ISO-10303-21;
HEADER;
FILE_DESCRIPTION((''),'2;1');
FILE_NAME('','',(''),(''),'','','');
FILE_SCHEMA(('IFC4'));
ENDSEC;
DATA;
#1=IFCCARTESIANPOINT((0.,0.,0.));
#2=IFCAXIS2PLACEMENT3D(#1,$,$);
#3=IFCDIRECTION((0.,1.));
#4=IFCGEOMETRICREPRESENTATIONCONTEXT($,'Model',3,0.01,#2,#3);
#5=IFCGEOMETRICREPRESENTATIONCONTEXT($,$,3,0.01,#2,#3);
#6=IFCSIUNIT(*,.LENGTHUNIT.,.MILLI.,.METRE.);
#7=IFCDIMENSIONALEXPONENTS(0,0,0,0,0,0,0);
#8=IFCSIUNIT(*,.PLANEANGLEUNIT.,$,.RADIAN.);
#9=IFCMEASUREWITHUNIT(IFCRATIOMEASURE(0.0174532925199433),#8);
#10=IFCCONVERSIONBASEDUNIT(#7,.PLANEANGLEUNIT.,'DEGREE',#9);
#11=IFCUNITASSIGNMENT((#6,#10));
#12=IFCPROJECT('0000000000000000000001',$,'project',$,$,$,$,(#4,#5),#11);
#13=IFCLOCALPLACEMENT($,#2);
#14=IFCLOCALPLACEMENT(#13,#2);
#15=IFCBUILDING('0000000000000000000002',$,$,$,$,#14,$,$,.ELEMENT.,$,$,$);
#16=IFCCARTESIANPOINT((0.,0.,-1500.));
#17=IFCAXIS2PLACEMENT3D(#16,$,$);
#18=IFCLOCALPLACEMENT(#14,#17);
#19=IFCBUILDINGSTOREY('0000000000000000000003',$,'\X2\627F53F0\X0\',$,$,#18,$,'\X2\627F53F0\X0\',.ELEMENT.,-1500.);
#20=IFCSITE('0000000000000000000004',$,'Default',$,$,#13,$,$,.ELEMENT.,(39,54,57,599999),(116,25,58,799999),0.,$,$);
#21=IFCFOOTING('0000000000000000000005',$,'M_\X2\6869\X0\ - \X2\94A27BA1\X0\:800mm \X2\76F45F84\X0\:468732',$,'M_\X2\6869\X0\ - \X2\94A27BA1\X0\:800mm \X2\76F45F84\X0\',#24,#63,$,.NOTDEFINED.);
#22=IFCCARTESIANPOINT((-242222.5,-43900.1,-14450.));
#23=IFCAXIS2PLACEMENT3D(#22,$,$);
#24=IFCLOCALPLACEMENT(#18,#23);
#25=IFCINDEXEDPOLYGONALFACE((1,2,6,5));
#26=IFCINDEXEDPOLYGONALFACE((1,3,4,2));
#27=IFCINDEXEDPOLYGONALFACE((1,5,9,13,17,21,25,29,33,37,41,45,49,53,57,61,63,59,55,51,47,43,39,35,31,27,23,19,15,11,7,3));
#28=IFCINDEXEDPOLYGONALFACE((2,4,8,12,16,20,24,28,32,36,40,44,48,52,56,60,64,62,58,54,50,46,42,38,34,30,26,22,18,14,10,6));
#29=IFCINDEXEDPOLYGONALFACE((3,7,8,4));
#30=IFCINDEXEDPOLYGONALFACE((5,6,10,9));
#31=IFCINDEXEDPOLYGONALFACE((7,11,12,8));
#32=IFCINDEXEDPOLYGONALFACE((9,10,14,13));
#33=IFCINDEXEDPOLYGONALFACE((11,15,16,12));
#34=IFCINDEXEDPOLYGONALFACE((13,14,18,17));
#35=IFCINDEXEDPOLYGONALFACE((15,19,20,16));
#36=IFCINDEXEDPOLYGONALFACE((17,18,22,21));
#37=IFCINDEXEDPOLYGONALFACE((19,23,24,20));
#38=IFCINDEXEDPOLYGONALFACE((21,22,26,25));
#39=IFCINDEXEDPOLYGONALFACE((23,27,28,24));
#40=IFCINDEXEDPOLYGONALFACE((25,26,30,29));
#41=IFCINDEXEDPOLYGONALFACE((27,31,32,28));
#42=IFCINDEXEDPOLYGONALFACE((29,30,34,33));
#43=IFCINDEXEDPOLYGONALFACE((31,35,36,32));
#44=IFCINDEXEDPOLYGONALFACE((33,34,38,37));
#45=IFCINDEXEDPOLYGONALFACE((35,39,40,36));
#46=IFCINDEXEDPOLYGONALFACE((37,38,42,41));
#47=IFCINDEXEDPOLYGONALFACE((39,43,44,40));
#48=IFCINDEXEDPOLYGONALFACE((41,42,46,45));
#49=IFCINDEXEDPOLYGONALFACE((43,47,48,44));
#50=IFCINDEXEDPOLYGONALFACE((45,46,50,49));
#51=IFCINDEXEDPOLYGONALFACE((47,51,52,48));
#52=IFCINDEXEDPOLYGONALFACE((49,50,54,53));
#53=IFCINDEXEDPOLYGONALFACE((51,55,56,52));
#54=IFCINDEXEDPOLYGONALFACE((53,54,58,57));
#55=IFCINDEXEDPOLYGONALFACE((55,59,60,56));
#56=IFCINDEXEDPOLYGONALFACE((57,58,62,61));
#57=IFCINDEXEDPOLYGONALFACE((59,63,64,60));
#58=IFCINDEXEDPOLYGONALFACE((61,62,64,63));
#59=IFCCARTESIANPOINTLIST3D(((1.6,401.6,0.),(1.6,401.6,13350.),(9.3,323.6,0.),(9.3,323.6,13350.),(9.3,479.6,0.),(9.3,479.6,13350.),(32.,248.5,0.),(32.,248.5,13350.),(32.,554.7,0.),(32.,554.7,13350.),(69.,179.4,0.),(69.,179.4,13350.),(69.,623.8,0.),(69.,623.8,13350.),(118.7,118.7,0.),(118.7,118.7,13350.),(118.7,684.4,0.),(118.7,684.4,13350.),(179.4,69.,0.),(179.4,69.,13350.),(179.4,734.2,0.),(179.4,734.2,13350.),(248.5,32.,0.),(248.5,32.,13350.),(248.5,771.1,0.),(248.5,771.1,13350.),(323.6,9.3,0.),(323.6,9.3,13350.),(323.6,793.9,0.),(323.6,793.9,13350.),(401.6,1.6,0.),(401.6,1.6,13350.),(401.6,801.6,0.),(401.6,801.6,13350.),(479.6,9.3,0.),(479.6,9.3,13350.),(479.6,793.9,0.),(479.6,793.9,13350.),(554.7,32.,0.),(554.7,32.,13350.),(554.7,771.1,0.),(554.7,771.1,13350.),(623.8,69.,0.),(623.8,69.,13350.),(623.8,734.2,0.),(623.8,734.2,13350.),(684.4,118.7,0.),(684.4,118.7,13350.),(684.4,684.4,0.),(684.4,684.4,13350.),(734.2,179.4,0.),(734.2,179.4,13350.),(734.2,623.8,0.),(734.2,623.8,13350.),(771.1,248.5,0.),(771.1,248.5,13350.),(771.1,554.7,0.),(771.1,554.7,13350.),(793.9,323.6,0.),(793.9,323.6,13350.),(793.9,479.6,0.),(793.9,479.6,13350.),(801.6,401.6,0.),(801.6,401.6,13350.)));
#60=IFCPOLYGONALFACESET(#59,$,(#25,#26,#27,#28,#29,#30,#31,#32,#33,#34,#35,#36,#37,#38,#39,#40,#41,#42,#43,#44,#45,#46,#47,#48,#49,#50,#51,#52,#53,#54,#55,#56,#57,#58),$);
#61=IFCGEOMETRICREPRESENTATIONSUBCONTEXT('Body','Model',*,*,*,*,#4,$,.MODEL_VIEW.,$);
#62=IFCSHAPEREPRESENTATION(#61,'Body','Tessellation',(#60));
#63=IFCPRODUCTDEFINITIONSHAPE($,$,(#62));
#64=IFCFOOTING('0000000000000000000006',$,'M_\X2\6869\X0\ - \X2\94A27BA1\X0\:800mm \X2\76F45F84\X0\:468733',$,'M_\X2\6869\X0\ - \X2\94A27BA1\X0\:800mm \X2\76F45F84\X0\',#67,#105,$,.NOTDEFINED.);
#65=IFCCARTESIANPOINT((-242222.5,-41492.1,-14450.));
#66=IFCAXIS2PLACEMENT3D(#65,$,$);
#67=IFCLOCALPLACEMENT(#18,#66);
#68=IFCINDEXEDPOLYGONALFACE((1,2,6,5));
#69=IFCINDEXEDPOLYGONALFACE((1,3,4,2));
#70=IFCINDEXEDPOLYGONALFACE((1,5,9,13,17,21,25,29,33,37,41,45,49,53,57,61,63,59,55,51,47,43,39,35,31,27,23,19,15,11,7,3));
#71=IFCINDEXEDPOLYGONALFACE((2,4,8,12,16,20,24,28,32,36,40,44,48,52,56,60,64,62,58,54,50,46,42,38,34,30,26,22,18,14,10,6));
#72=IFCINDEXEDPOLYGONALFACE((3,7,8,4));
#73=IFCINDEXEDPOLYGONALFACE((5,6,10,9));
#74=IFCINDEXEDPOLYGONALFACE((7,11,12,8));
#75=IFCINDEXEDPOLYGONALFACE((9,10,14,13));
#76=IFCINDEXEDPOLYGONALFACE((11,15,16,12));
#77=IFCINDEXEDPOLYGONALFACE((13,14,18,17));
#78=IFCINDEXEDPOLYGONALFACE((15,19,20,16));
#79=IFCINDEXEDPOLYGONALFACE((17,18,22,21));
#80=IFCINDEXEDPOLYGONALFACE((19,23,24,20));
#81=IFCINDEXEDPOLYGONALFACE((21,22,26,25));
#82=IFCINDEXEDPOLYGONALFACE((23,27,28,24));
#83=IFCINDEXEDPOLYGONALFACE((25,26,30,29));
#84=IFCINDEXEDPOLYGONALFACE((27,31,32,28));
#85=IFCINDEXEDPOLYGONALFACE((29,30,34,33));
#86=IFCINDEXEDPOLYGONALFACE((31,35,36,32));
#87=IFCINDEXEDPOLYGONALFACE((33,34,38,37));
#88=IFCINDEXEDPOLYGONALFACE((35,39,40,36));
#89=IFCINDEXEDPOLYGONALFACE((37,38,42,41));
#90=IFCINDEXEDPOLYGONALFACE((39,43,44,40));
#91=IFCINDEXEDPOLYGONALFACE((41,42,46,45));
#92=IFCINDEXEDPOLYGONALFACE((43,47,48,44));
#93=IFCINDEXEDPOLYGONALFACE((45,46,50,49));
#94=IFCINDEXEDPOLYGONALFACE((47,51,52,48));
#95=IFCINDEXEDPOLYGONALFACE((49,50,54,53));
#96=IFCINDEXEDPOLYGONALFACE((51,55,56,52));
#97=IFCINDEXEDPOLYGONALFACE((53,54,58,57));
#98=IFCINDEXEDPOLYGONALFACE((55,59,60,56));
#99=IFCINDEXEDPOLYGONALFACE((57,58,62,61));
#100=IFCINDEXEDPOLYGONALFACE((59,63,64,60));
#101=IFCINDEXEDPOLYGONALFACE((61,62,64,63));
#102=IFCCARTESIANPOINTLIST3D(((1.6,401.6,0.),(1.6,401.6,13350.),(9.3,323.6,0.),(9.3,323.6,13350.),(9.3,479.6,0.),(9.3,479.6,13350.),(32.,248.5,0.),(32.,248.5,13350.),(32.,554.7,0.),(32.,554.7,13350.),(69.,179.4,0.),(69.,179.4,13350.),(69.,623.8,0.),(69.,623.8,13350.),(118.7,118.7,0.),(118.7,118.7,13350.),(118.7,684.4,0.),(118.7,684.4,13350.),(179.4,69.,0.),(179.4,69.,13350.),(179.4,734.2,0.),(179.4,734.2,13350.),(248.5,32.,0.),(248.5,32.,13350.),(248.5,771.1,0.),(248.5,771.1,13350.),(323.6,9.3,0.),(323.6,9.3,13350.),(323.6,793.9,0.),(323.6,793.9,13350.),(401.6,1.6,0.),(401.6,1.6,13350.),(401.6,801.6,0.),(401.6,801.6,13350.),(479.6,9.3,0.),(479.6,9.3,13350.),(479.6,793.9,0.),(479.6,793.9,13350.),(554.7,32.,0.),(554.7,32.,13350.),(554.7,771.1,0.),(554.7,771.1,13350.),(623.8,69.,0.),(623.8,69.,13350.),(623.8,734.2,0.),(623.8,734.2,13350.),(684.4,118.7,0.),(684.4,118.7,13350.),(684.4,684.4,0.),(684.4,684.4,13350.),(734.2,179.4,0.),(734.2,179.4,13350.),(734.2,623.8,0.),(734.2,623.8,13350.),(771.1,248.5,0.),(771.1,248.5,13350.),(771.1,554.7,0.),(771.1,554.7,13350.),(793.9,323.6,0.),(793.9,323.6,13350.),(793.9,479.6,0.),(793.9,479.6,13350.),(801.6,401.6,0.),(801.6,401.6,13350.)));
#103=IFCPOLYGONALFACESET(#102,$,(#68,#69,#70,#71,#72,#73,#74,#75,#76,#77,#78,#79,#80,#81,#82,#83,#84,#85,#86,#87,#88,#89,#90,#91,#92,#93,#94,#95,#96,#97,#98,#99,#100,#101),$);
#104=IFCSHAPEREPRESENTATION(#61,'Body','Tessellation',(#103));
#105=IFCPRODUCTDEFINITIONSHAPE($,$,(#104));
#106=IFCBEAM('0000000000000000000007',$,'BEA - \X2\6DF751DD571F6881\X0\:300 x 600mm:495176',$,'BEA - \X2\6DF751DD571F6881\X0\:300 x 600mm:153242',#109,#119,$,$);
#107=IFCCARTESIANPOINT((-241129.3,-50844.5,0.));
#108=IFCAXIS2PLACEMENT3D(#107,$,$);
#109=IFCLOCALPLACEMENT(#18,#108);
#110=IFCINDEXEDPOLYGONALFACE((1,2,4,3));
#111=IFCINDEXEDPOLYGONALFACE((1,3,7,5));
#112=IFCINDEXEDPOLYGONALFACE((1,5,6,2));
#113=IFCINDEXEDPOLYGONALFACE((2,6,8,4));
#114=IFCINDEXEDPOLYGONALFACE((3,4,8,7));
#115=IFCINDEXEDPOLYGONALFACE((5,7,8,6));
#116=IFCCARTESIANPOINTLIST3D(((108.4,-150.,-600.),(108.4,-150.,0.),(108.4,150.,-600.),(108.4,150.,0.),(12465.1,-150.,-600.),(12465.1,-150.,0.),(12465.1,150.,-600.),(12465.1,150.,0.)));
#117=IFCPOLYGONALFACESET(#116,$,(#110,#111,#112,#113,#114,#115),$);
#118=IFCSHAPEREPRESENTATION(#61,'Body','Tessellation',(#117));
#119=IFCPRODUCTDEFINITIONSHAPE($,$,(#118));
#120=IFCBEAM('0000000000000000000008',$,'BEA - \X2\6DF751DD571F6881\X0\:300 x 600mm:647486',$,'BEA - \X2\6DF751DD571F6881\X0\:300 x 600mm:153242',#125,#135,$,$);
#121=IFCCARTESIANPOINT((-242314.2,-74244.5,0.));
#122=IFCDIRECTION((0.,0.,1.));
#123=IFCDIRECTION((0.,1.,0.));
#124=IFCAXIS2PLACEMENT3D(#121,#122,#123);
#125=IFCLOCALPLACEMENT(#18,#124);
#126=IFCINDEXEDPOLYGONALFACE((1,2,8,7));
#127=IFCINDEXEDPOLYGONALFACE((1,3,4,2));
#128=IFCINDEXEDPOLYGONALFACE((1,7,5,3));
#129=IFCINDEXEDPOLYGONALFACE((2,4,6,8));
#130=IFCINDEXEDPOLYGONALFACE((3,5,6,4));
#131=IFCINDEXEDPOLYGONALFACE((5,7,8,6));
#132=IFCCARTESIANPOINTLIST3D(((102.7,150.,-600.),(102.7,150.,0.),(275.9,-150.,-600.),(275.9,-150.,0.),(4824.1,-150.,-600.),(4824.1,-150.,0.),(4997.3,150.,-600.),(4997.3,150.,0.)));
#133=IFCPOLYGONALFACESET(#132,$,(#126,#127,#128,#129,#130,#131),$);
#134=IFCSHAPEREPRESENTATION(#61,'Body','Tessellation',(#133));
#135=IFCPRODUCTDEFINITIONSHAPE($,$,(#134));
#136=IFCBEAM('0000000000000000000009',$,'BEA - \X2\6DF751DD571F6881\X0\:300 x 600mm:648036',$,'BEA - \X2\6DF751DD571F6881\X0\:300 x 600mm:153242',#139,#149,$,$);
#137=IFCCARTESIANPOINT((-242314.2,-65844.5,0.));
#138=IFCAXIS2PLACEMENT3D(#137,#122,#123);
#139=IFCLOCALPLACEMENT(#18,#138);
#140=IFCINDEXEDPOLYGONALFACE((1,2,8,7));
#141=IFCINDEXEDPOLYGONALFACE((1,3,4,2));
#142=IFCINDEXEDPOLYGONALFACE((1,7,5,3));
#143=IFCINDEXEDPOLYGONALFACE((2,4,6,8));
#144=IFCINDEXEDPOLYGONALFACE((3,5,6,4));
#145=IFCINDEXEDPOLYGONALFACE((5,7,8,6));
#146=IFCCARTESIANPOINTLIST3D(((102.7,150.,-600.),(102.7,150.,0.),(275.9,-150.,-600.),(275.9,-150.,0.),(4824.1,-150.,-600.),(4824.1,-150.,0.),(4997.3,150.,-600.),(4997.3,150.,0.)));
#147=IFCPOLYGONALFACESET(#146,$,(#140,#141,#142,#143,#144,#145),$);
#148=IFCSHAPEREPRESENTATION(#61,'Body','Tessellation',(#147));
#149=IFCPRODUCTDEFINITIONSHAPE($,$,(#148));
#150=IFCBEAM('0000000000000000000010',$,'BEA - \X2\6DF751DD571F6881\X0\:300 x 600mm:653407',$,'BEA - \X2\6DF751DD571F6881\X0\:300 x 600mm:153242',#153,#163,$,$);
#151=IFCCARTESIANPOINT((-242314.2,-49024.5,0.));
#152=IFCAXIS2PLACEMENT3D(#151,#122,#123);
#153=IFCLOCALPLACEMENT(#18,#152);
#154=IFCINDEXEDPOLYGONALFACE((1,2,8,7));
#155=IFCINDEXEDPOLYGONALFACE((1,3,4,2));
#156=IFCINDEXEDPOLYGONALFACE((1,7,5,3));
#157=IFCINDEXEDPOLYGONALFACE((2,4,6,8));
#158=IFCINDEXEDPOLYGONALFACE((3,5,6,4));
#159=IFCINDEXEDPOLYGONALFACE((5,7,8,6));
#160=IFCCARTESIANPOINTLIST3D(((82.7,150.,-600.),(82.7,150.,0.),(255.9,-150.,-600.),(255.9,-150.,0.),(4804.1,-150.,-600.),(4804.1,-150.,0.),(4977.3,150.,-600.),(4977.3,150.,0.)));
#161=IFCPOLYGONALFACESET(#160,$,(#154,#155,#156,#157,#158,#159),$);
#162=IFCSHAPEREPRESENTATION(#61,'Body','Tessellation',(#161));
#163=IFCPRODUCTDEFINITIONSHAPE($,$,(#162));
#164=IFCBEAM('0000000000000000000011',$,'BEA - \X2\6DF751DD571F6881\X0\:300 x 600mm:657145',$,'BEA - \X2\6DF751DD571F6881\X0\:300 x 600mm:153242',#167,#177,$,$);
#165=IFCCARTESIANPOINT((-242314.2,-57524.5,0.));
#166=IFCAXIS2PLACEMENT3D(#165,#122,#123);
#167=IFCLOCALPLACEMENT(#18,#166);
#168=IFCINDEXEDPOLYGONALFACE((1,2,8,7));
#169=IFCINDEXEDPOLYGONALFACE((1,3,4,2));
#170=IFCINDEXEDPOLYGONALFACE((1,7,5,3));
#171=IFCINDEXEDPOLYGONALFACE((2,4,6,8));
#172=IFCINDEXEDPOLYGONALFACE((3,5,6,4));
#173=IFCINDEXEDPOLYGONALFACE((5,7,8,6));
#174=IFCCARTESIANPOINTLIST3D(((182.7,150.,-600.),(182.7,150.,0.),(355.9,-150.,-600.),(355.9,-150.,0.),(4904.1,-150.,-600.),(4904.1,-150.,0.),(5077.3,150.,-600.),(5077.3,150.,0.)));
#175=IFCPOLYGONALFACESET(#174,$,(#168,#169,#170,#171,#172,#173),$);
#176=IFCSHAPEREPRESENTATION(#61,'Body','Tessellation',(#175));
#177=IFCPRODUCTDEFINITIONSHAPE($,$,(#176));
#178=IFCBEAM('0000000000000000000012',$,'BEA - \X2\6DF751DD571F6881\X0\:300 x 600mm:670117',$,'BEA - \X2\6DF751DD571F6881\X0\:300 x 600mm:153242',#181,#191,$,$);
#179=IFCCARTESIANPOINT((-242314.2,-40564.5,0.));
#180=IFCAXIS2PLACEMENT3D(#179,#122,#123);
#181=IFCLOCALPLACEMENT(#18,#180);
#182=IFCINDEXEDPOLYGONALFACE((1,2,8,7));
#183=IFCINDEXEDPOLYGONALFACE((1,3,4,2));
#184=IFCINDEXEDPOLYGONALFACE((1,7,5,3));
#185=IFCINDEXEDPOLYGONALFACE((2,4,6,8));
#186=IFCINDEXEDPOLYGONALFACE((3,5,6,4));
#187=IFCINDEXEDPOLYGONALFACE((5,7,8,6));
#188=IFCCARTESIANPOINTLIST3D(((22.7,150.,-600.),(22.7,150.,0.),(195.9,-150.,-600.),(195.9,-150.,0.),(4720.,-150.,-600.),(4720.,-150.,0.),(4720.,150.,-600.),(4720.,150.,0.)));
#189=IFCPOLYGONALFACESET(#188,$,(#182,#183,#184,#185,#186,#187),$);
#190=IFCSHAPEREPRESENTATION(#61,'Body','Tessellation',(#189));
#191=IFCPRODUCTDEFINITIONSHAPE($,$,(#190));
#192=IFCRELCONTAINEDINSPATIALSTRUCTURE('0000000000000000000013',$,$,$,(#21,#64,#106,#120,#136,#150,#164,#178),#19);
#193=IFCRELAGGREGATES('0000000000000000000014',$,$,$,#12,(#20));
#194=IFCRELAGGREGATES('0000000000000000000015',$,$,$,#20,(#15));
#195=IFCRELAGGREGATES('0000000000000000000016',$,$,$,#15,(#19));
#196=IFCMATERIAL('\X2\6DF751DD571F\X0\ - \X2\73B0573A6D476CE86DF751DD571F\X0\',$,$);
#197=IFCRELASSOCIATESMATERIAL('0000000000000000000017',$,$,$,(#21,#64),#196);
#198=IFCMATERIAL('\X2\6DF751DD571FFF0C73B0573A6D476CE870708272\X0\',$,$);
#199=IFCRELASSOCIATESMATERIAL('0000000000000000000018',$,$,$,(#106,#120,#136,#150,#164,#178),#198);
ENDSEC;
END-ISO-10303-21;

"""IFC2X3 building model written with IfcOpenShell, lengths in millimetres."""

from ifc_helpers import new_model, entity, si_unit, converted_unit, direction, frame, frame_2d, origin, origin_2d_with_axis, place, context, subcontext, project, spatial, rectangle, circle, extrude, clip, halfspace, material, element, save


model = new_model("IFC2X3")

# Units and contexts
model_context = context("Model", 3, precision=0.01, world=origin(), true_north=direction((0.0, 1.0)))
context_of_model = context(None, 3, precision=0.01, world=origin(), true_north=direction((0.0, 1.0)))
body_context = subcontext(model_context, "Body", "Model", "MODEL_VIEW")
ifc_project = project(units=[si_unit("LENGTHUNIT", "METRE", prefix="MILLI"), converted_unit("PLANEANGLEUNIT", "DEGREE", entity("IfcRatioMeasure", 0.0174532925199433), si_unit("PLANEANGLEUNIT", "RADIAN"), dimensions=[0, 0, 0, 0, 0, 0, 0])], contexts=[model_context, context_of_model])

# Site, building, storey
site_placement = place(None, origin())
site = spatial("IfcSite", under=ifc_project, at=site_placement, Name="Default", CompositionType="ELEMENT", RefLatitude=(39, 54, 57, 599999), RefLongitude=(116, 25, 58, 799999), RefElevation=0.0)
building_placement = place(site_placement, origin())
building = spatial("IfcBuilding", under=site, at=building_placement, CompositionType="ELEMENT")
storey_placement = place(building_placement, frame((0.0, 0.0, -1500.0)))
storey = spatial("IfcBuildingStorey", under=building, at=storey_placement, Name="承台", LongName="承台", CompositionType="ELEMENT", Elevation=-1500.0)

# Footings
ifc_material_1 = material(Name="混凝土 - 现场浇注混凝土")
for number, where, name in (
    (1, (-242222.5, -43900.1, -14450.0), "M_桩 - 钢管:800mm 直径:468732"),
    (2, (-242222.5, -41492.1, -14450.0), "M_桩 - 钢管:800mm 直径:468733"),
):
    element("IfcFooting", number, at=place(storey_placement, frame(where)), inside=storey, material=ifc_material_1, Name=name, ObjectType="M_桩 - 钢管:800mm 直径", PredefinedType="NOTDEFINED", context=body_context, shape_type="SweptSolid", body=[
        extrude(circle(Radius=400.0, at=origin_2d_with_axis()), frame((401.6, 401.6, 0.0), z_axis=(0.0, 0.0, 1.0), x_axis=(0.0, 1.0, 0.0)), (0.0, 0.0, 1.0), 13350.0),
    ])

# Beams
ifc_material_2 = material(Name="混凝土，现场浇注灰色")
beam_1_placement = place(storey_placement, frame((-241129.3, -50844.5, 0.0)))
element("IfcBeam", 3, at=beam_1_placement, inside=storey, material=ifc_material_2, Name="BEA - 混凝土梁:300 x 600mm:495176", ObjectType="BEA - 混凝土梁:300 x 600mm:153242", context=body_context, shape_type="SweptSolid", body=[
    extrude(rectangle(XDim=600.0, YDim=300.0, at=frame_2d((0.0, 0.0), x_axis=(1.0, 0.0))), frame((108.4, 0.0, -300.0), z_axis=(1.0, 0.0, 0.0), x_axis=(0.0, 0.0, -1.0)), (0.0, 0.0, 1.0), 12356.7),
])
beam_2_placement = place(storey_placement, frame((-242314.2, -74244.5, 0.0), z_axis=(0.0, 0.0, 1.0), x_axis=(0.0, 1.0, 0.0)))
element("IfcBeam", 4, at=beam_2_placement, inside=storey, material=ifc_material_2, Name="BEA - 混凝土梁:300 x 600mm:647486", ObjectType="BEA - 混凝土梁:300 x 600mm:153242", context=body_context, shape_type="Clipping", body=[
    clip(clip(extrude(rectangle(XDim=600.0, YDim=300.0, at=frame_2d((0.0, 0.0), x_axis=(1.0, 0.0))), frame((102.7, 0.0, -300.0), z_axis=(1.0, 0.0, 0.0), x_axis=(0.0, 0.0, -1.0)), (0.0, 0.0, 1.0), 4894.5), halfspace(frame((6288.0, 2386.7, 0.0), z_axis=(0.866125, -0.499827, 0.0), x_axis=(-0.499827, -0.866125, 0.0)), False)), halfspace(frame((474.0, -493.3, 0.0), z_axis=(-0.866125, -0.499827, 0.0), x_axis=(0.499827, -0.866125, 0.0)), False)),
])
beam_3_placement = place(storey_placement, frame((-242314.2, -65844.5, 0.0), z_axis=(0.0, 0.0, 1.0), x_axis=(0.0, 1.0, 0.0)))
element("IfcBeam", 5, at=beam_3_placement, inside=storey, material=ifc_material_2, Name="BEA - 混凝土梁:300 x 600mm:648036", ObjectType="BEA - 混凝土梁:300 x 600mm:153242", context=body_context, shape_type="Clipping", body=[
    clip(clip(extrude(rectangle(XDim=600.0, YDim=300.0, at=origin_2d_with_axis()), frame((102.7, 0.0, -300.0), z_axis=(1.0, 0.0, 0.0), x_axis=(0.0, 0.0, -1.0)), (0.0, 0.0, 1.0), 4894.5), halfspace(frame((6288.0, 2386.7, 0.0), z_axis=(0.866125, -0.499827, 0.0), x_axis=(-0.499827, -0.866125, 0.0)), False)), halfspace(frame((474.0, -493.3, 0.0), z_axis=(-0.866125, -0.499827, 0.0), x_axis=(0.499827, -0.866125, 0.0)), False)),
])
beam_4_placement = place(storey_placement, frame((-242314.2, -49024.5, 0.0), z_axis=(0.0, 0.0, 1.0), x_axis=(0.0, 1.0, 0.0)))
element("IfcBeam", 6, at=beam_4_placement, inside=storey, material=ifc_material_2, Name="BEA - 混凝土梁:300 x 600mm:653407", ObjectType="BEA - 混凝土梁:300 x 600mm:153242", context=body_context, shape_type="Clipping", body=[
    clip(clip(extrude(rectangle(XDim=600.0, YDim=300.0, at=origin_2d_with_axis()), frame((82.7, 0.0, -300.0), z_axis=(1.0, 0.0, 0.0), x_axis=(0.0, 0.0, -1.0)), (0.0, 0.0, 1.0), 4894.5), halfspace(frame((6268.0, 2386.7, 0.0), z_axis=(0.866125, -0.499827, 0.0), x_axis=(-0.499827, -0.866125, 0.0)), False)), halfspace(frame((454.0, -493.3, 0.0), z_axis=(-0.866125, -0.499827, 0.0), x_axis=(0.499827, -0.866125, 0.0)), False)),
])
beam_5_placement = place(storey_placement, frame((-242314.2, -57524.5, 0.0), z_axis=(0.0, 0.0, 1.0), x_axis=(0.0, 1.0, 0.0)))
element("IfcBeam", 7, at=beam_5_placement, inside=storey, material=ifc_material_2, Name="BEA - 混凝土梁:300 x 600mm:657145", ObjectType="BEA - 混凝土梁:300 x 600mm:153242", context=body_context, shape_type="Clipping", body=[
    clip(clip(extrude(rectangle(XDim=600.0, YDim=300.0, at=origin_2d_with_axis()), frame((182.7, 0.0, -300.0), z_axis=(1.0, 0.0, 0.0), x_axis=(0.0, 0.0, -1.0)), (0.0, 0.0, 1.0), 4894.5), halfspace(frame((6368.0, 2386.7, 0.0), z_axis=(0.866125, -0.499827, 0.0), x_axis=(-0.499827, -0.866125, 0.0)), False)), halfspace(frame((554.0, -493.3, 0.0), z_axis=(-0.866125, -0.499827, 0.0), x_axis=(0.499827, -0.866125, 0.0)), False)),
])
beam_6_placement = place(storey_placement, frame((-242314.2, -40564.5, 0.0), z_axis=(0.0, 0.0, 1.0), x_axis=(0.0, 1.0, 0.0)))
element("IfcBeam", 8, at=beam_6_placement, inside=storey, material=ifc_material_2, Name="BEA - 混凝土梁:300 x 600mm:670117", ObjectType="BEA - 混凝土梁:300 x 600mm:153242", context=body_context, shape_type="Clipping", body=[
    clip(extrude(rectangle(XDim=600.0, YDim=300.0, at=origin_2d_with_axis()), frame((22.7, 0.0, -300.0), z_axis=(1.0, 0.0, 0.0), x_axis=(0.0, 0.0, -1.0)), (0.0, 0.0, 1.0), 4697.3), halfspace(frame((394.0, -493.3, 0.0), z_axis=(-0.866125, -0.499827, 0.0), x_axis=(0.499827, -0.866125, 0.0)), False)),
])

save(model, "model.ifc")
